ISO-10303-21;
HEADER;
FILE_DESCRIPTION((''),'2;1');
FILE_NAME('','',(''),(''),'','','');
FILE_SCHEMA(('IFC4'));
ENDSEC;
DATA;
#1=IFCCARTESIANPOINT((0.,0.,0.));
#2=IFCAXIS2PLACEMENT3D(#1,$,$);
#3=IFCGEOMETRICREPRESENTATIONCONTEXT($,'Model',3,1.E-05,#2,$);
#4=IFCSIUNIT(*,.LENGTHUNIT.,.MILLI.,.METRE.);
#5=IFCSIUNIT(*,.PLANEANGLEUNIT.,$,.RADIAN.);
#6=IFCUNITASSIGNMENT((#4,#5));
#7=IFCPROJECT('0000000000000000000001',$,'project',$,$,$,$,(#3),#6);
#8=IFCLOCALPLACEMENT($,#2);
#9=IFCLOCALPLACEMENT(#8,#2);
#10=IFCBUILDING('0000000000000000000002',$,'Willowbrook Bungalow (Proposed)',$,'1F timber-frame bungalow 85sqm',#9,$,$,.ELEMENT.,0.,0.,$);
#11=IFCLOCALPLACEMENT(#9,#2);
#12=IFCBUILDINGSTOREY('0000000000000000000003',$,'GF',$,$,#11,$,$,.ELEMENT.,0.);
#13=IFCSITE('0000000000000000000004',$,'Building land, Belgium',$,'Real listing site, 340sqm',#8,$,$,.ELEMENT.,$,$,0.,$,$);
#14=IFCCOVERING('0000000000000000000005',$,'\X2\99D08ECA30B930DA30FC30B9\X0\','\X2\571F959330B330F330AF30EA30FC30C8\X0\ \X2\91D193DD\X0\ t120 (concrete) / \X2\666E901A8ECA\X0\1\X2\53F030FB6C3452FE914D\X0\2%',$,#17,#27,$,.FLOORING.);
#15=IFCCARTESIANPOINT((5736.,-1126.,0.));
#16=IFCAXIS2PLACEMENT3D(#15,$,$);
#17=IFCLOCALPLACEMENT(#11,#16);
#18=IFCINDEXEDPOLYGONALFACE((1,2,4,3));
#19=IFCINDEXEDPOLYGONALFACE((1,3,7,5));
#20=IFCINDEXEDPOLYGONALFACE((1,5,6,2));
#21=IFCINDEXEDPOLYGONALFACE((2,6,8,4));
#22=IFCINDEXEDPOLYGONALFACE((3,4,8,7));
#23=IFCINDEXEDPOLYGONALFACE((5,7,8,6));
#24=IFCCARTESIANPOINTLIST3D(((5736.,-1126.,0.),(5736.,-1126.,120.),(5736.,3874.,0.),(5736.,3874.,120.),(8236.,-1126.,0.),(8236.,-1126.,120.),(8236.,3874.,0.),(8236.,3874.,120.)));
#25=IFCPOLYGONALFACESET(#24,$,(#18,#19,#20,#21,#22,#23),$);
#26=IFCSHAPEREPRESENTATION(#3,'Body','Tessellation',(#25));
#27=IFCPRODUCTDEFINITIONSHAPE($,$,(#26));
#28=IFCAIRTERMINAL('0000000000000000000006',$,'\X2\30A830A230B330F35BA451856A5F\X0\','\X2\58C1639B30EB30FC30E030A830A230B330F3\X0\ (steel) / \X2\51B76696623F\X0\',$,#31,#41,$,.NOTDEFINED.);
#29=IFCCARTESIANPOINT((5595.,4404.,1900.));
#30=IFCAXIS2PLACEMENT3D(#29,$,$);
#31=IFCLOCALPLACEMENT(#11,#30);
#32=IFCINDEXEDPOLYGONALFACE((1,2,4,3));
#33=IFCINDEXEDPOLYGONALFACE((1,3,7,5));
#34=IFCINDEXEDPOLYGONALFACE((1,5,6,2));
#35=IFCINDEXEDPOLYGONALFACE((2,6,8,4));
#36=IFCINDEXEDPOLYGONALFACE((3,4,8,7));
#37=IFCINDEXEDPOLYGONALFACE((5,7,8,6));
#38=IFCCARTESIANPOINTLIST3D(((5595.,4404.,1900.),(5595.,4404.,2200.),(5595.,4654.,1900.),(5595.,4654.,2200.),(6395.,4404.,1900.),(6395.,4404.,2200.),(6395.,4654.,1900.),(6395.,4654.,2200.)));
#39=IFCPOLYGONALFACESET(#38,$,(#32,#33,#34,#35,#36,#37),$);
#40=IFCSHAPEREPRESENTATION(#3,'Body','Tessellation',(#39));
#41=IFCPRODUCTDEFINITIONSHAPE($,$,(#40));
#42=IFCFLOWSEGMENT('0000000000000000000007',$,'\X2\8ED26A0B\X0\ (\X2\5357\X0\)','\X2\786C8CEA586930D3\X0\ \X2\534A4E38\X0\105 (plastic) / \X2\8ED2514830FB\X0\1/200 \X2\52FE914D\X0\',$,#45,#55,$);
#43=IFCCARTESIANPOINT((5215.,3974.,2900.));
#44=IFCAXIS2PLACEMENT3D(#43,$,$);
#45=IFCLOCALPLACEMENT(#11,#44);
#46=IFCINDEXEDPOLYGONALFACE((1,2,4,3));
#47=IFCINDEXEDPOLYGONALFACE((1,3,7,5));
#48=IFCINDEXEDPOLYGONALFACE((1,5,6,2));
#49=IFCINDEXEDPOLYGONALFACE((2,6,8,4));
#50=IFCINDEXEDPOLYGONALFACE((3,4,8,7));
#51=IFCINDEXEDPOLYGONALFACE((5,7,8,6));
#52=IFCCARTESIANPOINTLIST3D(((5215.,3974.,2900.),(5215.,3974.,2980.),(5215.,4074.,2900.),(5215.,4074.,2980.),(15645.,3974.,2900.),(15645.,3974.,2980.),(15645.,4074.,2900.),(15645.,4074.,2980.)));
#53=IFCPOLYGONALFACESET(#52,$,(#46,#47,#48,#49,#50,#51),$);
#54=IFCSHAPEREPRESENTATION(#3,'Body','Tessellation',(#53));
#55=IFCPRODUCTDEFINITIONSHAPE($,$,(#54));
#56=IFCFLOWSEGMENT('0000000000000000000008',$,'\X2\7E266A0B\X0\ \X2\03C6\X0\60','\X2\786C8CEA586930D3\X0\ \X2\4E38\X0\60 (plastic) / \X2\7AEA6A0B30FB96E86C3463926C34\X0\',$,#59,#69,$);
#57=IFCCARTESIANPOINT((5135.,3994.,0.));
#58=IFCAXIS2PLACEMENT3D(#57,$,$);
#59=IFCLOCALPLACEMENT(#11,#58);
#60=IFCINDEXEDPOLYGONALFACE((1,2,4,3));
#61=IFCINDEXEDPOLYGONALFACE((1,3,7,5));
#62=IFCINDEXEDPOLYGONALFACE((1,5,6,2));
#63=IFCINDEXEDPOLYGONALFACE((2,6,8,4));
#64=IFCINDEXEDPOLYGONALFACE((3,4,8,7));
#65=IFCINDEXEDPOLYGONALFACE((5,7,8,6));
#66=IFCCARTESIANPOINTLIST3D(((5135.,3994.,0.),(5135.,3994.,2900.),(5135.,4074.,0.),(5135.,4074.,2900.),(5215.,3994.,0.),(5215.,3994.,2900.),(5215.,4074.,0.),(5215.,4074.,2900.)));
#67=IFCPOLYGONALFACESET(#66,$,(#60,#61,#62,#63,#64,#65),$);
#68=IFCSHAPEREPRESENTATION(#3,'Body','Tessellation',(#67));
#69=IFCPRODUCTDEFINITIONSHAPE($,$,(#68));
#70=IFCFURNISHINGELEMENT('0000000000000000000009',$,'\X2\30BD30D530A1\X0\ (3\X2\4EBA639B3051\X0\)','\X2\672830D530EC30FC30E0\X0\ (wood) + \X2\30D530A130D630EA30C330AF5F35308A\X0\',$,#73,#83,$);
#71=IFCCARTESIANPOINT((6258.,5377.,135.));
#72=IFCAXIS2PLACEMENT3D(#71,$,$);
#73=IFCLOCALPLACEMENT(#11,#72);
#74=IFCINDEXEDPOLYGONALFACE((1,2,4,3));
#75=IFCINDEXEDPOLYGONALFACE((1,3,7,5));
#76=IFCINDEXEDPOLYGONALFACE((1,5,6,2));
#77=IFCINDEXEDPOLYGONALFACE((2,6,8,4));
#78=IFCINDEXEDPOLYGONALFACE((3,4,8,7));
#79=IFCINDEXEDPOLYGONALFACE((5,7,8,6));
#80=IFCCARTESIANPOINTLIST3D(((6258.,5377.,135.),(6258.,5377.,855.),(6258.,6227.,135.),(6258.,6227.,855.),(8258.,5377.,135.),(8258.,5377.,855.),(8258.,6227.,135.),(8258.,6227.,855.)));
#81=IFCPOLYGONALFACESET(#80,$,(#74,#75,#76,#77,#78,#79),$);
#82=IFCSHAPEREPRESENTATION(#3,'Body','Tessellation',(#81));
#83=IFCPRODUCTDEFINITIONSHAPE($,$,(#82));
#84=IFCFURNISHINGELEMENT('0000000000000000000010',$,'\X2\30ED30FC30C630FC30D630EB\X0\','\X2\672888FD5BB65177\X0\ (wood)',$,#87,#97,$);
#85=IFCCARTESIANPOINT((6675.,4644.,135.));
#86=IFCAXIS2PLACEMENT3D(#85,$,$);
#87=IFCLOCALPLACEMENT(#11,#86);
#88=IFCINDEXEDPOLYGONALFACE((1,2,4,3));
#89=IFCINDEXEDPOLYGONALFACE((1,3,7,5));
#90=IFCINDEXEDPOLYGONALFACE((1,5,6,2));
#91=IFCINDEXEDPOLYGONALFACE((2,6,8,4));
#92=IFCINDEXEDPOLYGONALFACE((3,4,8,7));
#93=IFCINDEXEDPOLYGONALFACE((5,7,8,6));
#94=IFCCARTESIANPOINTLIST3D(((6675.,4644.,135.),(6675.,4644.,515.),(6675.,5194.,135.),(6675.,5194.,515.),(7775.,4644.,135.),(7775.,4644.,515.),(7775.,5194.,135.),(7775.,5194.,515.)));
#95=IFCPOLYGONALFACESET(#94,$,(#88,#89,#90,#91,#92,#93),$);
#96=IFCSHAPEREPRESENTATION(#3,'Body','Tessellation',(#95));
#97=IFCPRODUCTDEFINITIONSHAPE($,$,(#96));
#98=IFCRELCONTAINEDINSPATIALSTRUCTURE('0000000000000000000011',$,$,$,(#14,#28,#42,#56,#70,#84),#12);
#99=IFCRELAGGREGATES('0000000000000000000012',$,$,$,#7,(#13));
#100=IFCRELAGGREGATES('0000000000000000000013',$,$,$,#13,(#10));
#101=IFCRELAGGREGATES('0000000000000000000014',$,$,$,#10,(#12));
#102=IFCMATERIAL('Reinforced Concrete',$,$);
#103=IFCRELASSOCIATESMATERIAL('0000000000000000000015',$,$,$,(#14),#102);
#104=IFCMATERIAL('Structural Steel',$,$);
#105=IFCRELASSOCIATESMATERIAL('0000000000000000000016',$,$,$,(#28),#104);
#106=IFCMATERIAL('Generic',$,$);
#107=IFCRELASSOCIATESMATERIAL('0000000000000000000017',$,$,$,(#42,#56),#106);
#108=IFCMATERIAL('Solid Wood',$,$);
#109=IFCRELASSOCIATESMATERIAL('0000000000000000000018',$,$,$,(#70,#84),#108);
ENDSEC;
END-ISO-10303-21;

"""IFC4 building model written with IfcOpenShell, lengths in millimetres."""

from ifc_helpers import new_model, si_unit, frame, frame_2d, origin, place, context, project, spatial, rectangle, extrude, material, element, save


model = new_model("IFC4")

# Units and contexts
model_context = context("Model", 3, precision=1e-05, world=origin())
ifc_project = project(units=[si_unit("LENGTHUNIT", "METRE", prefix="MILLI"), si_unit("PLANEANGLEUNIT", "RADIAN")], contexts=[model_context])

# Site, building, storey
site_placement = place(None, origin())
site = spatial("IfcSite", under=ifc_project, at=site_placement, Name="Building land, Belgium", ObjectType="Real listing site, 340sqm", CompositionType="ELEMENT", RefElevation=0.0)
building_placement = place(site_placement, origin())
building = spatial("IfcBuilding", under=site, at=building_placement, Name="Willowbrook Bungalow (Proposed)", ObjectType="1F timber-frame bungalow 85sqm", CompositionType="ELEMENT", ElevationOfRefHeight=0.0, ElevationOfTerrain=0.0)
storey_placement = place(building_placement, origin())
storey = spatial("IfcBuildingStorey", under=building, at=storey_placement, Name="GF", CompositionType="ELEMENT", Elevation=0.0)

# Shared definitions
ifc_material_1 = material(Name="Solid Wood")

# Shared definitions
ifc_material_2 = material(Name="Reinforced Concrete")

# Shared definitions
ifc_material_3 = material(Name="Structural Steel")

# Covering
ifc_material_4 = material(Name="Generic")
covering_1_placement = place(storey_placement, frame((5736.0, -1126.0, 0.0)))
element("IfcCovering", 1, at=covering_1_placement, inside=storey, material=ifc_material_2, Name="駐車スペース", Description="土間コンクリート 金鏝 t120 (concrete) / 普通車1台・水勾配2%", PredefinedType="FLOORING", context=model_context, shape_type="SweptSolid", body=[
    extrude(rectangle(XDim=2500.0, YDim=5000.0, at=frame_2d((1250.0, 2500.0))), frame((5736.0, -1126.0, 0.0)), (0.0, 0.0, 1.0), 120.0),
])

# Air terminal
air_terminal_placement = place(storey_placement, frame((5595.0, 4404.0, 1900.0)))
element("IfcAirTerminal", 2, at=air_terminal_placement, inside=storey, material=ifc_material_3, Name="エアコン室内機", Description="壁掛ルームエアコン (steel) / 冷暖房", PredefinedType="NOTDEFINED", context=model_context, shape_type="SweptSolid", body=[
    extrude(rectangle(XDim=800.0, YDim=250.0, at=frame_2d((400.0, 125.0))), frame((5595.0, 4404.0, 1900.0)), (0.0, 0.0, 1.0), 300.0),
])

# Flow segments
flow_segment_1_placement = place(storey_placement, frame((5215.0, 3974.0, 2900.0)))
element("IfcFlowSegment", 3, at=flow_segment_1_placement, inside=storey, material=ifc_material_4, Name="軒樋 (南)", Description="硬質塩ビ 半丸105 (plastic) / 軒先・1/200 勾配", context=model_context, shape_type="SweptSolid", body=[
    extrude(rectangle(XDim=10430.0, YDim=100.0, at=frame_2d((5215.0, 50.0))), frame((5215.0, 3974.0, 2900.0)), (0.0, 0.0, 1.0), 80.0),
])
flow_segment_2_placement = place(storey_placement, frame((5135.0, 3994.0, 0.0)))
element("IfcFlowSegment", 4, at=flow_segment_2_placement, inside=storey, material=ifc_material_4, Name="縦樋 φ60", Description="硬質塩ビ 丸60 (plastic) / 竪樋・雨水排水", context=model_context, shape_type="SweptSolid", body=[
    extrude(rectangle(XDim=80.0, YDim=80.0, at=frame_2d((40.0, 40.0))), frame((5135.0, 3994.0, 0.0)), (0.0, 0.0, 1.0), 2900.0),
])

# Furnishing elements
furnishing_1_placement = place(storey_placement, frame((6258.0, 5377.0, 135.0)))
element("IfcFurnishingElement", 5, at=furnishing_1_placement, inside=storey, material=ifc_material_1, Name="ソファ (3人掛け)", Description="木フレーム (wood) + ファブリック張り", context=model_context, shape_type="SweptSolid", body=[
    extrude(rectangle(XDim=2000.0, YDim=850.0, at=frame_2d((1000.0, 425.0))), frame((6258.0, 5377.0, 135.0)), (0.0, 0.0, 1.0), 720.0),
])
furnishing_2_placement = place(storey_placement, frame((6675.0, 4644.0, 135.0)))
element("IfcFurnishingElement", 6, at=furnishing_2_placement, inside=storey, material=ifc_material_1, Name="ローテーブル", Description="木製家具 (wood)", context=model_context, shape_type="SweptSolid", body=[
    extrude(rectangle(XDim=1100.0, YDim=550.0, at=frame_2d((550.0, 275.0))), frame((6675.0, 4644.0, 135.0)), (0.0, 0.0, 1.0), 380.0),
])

save(model, "model.ifc")
